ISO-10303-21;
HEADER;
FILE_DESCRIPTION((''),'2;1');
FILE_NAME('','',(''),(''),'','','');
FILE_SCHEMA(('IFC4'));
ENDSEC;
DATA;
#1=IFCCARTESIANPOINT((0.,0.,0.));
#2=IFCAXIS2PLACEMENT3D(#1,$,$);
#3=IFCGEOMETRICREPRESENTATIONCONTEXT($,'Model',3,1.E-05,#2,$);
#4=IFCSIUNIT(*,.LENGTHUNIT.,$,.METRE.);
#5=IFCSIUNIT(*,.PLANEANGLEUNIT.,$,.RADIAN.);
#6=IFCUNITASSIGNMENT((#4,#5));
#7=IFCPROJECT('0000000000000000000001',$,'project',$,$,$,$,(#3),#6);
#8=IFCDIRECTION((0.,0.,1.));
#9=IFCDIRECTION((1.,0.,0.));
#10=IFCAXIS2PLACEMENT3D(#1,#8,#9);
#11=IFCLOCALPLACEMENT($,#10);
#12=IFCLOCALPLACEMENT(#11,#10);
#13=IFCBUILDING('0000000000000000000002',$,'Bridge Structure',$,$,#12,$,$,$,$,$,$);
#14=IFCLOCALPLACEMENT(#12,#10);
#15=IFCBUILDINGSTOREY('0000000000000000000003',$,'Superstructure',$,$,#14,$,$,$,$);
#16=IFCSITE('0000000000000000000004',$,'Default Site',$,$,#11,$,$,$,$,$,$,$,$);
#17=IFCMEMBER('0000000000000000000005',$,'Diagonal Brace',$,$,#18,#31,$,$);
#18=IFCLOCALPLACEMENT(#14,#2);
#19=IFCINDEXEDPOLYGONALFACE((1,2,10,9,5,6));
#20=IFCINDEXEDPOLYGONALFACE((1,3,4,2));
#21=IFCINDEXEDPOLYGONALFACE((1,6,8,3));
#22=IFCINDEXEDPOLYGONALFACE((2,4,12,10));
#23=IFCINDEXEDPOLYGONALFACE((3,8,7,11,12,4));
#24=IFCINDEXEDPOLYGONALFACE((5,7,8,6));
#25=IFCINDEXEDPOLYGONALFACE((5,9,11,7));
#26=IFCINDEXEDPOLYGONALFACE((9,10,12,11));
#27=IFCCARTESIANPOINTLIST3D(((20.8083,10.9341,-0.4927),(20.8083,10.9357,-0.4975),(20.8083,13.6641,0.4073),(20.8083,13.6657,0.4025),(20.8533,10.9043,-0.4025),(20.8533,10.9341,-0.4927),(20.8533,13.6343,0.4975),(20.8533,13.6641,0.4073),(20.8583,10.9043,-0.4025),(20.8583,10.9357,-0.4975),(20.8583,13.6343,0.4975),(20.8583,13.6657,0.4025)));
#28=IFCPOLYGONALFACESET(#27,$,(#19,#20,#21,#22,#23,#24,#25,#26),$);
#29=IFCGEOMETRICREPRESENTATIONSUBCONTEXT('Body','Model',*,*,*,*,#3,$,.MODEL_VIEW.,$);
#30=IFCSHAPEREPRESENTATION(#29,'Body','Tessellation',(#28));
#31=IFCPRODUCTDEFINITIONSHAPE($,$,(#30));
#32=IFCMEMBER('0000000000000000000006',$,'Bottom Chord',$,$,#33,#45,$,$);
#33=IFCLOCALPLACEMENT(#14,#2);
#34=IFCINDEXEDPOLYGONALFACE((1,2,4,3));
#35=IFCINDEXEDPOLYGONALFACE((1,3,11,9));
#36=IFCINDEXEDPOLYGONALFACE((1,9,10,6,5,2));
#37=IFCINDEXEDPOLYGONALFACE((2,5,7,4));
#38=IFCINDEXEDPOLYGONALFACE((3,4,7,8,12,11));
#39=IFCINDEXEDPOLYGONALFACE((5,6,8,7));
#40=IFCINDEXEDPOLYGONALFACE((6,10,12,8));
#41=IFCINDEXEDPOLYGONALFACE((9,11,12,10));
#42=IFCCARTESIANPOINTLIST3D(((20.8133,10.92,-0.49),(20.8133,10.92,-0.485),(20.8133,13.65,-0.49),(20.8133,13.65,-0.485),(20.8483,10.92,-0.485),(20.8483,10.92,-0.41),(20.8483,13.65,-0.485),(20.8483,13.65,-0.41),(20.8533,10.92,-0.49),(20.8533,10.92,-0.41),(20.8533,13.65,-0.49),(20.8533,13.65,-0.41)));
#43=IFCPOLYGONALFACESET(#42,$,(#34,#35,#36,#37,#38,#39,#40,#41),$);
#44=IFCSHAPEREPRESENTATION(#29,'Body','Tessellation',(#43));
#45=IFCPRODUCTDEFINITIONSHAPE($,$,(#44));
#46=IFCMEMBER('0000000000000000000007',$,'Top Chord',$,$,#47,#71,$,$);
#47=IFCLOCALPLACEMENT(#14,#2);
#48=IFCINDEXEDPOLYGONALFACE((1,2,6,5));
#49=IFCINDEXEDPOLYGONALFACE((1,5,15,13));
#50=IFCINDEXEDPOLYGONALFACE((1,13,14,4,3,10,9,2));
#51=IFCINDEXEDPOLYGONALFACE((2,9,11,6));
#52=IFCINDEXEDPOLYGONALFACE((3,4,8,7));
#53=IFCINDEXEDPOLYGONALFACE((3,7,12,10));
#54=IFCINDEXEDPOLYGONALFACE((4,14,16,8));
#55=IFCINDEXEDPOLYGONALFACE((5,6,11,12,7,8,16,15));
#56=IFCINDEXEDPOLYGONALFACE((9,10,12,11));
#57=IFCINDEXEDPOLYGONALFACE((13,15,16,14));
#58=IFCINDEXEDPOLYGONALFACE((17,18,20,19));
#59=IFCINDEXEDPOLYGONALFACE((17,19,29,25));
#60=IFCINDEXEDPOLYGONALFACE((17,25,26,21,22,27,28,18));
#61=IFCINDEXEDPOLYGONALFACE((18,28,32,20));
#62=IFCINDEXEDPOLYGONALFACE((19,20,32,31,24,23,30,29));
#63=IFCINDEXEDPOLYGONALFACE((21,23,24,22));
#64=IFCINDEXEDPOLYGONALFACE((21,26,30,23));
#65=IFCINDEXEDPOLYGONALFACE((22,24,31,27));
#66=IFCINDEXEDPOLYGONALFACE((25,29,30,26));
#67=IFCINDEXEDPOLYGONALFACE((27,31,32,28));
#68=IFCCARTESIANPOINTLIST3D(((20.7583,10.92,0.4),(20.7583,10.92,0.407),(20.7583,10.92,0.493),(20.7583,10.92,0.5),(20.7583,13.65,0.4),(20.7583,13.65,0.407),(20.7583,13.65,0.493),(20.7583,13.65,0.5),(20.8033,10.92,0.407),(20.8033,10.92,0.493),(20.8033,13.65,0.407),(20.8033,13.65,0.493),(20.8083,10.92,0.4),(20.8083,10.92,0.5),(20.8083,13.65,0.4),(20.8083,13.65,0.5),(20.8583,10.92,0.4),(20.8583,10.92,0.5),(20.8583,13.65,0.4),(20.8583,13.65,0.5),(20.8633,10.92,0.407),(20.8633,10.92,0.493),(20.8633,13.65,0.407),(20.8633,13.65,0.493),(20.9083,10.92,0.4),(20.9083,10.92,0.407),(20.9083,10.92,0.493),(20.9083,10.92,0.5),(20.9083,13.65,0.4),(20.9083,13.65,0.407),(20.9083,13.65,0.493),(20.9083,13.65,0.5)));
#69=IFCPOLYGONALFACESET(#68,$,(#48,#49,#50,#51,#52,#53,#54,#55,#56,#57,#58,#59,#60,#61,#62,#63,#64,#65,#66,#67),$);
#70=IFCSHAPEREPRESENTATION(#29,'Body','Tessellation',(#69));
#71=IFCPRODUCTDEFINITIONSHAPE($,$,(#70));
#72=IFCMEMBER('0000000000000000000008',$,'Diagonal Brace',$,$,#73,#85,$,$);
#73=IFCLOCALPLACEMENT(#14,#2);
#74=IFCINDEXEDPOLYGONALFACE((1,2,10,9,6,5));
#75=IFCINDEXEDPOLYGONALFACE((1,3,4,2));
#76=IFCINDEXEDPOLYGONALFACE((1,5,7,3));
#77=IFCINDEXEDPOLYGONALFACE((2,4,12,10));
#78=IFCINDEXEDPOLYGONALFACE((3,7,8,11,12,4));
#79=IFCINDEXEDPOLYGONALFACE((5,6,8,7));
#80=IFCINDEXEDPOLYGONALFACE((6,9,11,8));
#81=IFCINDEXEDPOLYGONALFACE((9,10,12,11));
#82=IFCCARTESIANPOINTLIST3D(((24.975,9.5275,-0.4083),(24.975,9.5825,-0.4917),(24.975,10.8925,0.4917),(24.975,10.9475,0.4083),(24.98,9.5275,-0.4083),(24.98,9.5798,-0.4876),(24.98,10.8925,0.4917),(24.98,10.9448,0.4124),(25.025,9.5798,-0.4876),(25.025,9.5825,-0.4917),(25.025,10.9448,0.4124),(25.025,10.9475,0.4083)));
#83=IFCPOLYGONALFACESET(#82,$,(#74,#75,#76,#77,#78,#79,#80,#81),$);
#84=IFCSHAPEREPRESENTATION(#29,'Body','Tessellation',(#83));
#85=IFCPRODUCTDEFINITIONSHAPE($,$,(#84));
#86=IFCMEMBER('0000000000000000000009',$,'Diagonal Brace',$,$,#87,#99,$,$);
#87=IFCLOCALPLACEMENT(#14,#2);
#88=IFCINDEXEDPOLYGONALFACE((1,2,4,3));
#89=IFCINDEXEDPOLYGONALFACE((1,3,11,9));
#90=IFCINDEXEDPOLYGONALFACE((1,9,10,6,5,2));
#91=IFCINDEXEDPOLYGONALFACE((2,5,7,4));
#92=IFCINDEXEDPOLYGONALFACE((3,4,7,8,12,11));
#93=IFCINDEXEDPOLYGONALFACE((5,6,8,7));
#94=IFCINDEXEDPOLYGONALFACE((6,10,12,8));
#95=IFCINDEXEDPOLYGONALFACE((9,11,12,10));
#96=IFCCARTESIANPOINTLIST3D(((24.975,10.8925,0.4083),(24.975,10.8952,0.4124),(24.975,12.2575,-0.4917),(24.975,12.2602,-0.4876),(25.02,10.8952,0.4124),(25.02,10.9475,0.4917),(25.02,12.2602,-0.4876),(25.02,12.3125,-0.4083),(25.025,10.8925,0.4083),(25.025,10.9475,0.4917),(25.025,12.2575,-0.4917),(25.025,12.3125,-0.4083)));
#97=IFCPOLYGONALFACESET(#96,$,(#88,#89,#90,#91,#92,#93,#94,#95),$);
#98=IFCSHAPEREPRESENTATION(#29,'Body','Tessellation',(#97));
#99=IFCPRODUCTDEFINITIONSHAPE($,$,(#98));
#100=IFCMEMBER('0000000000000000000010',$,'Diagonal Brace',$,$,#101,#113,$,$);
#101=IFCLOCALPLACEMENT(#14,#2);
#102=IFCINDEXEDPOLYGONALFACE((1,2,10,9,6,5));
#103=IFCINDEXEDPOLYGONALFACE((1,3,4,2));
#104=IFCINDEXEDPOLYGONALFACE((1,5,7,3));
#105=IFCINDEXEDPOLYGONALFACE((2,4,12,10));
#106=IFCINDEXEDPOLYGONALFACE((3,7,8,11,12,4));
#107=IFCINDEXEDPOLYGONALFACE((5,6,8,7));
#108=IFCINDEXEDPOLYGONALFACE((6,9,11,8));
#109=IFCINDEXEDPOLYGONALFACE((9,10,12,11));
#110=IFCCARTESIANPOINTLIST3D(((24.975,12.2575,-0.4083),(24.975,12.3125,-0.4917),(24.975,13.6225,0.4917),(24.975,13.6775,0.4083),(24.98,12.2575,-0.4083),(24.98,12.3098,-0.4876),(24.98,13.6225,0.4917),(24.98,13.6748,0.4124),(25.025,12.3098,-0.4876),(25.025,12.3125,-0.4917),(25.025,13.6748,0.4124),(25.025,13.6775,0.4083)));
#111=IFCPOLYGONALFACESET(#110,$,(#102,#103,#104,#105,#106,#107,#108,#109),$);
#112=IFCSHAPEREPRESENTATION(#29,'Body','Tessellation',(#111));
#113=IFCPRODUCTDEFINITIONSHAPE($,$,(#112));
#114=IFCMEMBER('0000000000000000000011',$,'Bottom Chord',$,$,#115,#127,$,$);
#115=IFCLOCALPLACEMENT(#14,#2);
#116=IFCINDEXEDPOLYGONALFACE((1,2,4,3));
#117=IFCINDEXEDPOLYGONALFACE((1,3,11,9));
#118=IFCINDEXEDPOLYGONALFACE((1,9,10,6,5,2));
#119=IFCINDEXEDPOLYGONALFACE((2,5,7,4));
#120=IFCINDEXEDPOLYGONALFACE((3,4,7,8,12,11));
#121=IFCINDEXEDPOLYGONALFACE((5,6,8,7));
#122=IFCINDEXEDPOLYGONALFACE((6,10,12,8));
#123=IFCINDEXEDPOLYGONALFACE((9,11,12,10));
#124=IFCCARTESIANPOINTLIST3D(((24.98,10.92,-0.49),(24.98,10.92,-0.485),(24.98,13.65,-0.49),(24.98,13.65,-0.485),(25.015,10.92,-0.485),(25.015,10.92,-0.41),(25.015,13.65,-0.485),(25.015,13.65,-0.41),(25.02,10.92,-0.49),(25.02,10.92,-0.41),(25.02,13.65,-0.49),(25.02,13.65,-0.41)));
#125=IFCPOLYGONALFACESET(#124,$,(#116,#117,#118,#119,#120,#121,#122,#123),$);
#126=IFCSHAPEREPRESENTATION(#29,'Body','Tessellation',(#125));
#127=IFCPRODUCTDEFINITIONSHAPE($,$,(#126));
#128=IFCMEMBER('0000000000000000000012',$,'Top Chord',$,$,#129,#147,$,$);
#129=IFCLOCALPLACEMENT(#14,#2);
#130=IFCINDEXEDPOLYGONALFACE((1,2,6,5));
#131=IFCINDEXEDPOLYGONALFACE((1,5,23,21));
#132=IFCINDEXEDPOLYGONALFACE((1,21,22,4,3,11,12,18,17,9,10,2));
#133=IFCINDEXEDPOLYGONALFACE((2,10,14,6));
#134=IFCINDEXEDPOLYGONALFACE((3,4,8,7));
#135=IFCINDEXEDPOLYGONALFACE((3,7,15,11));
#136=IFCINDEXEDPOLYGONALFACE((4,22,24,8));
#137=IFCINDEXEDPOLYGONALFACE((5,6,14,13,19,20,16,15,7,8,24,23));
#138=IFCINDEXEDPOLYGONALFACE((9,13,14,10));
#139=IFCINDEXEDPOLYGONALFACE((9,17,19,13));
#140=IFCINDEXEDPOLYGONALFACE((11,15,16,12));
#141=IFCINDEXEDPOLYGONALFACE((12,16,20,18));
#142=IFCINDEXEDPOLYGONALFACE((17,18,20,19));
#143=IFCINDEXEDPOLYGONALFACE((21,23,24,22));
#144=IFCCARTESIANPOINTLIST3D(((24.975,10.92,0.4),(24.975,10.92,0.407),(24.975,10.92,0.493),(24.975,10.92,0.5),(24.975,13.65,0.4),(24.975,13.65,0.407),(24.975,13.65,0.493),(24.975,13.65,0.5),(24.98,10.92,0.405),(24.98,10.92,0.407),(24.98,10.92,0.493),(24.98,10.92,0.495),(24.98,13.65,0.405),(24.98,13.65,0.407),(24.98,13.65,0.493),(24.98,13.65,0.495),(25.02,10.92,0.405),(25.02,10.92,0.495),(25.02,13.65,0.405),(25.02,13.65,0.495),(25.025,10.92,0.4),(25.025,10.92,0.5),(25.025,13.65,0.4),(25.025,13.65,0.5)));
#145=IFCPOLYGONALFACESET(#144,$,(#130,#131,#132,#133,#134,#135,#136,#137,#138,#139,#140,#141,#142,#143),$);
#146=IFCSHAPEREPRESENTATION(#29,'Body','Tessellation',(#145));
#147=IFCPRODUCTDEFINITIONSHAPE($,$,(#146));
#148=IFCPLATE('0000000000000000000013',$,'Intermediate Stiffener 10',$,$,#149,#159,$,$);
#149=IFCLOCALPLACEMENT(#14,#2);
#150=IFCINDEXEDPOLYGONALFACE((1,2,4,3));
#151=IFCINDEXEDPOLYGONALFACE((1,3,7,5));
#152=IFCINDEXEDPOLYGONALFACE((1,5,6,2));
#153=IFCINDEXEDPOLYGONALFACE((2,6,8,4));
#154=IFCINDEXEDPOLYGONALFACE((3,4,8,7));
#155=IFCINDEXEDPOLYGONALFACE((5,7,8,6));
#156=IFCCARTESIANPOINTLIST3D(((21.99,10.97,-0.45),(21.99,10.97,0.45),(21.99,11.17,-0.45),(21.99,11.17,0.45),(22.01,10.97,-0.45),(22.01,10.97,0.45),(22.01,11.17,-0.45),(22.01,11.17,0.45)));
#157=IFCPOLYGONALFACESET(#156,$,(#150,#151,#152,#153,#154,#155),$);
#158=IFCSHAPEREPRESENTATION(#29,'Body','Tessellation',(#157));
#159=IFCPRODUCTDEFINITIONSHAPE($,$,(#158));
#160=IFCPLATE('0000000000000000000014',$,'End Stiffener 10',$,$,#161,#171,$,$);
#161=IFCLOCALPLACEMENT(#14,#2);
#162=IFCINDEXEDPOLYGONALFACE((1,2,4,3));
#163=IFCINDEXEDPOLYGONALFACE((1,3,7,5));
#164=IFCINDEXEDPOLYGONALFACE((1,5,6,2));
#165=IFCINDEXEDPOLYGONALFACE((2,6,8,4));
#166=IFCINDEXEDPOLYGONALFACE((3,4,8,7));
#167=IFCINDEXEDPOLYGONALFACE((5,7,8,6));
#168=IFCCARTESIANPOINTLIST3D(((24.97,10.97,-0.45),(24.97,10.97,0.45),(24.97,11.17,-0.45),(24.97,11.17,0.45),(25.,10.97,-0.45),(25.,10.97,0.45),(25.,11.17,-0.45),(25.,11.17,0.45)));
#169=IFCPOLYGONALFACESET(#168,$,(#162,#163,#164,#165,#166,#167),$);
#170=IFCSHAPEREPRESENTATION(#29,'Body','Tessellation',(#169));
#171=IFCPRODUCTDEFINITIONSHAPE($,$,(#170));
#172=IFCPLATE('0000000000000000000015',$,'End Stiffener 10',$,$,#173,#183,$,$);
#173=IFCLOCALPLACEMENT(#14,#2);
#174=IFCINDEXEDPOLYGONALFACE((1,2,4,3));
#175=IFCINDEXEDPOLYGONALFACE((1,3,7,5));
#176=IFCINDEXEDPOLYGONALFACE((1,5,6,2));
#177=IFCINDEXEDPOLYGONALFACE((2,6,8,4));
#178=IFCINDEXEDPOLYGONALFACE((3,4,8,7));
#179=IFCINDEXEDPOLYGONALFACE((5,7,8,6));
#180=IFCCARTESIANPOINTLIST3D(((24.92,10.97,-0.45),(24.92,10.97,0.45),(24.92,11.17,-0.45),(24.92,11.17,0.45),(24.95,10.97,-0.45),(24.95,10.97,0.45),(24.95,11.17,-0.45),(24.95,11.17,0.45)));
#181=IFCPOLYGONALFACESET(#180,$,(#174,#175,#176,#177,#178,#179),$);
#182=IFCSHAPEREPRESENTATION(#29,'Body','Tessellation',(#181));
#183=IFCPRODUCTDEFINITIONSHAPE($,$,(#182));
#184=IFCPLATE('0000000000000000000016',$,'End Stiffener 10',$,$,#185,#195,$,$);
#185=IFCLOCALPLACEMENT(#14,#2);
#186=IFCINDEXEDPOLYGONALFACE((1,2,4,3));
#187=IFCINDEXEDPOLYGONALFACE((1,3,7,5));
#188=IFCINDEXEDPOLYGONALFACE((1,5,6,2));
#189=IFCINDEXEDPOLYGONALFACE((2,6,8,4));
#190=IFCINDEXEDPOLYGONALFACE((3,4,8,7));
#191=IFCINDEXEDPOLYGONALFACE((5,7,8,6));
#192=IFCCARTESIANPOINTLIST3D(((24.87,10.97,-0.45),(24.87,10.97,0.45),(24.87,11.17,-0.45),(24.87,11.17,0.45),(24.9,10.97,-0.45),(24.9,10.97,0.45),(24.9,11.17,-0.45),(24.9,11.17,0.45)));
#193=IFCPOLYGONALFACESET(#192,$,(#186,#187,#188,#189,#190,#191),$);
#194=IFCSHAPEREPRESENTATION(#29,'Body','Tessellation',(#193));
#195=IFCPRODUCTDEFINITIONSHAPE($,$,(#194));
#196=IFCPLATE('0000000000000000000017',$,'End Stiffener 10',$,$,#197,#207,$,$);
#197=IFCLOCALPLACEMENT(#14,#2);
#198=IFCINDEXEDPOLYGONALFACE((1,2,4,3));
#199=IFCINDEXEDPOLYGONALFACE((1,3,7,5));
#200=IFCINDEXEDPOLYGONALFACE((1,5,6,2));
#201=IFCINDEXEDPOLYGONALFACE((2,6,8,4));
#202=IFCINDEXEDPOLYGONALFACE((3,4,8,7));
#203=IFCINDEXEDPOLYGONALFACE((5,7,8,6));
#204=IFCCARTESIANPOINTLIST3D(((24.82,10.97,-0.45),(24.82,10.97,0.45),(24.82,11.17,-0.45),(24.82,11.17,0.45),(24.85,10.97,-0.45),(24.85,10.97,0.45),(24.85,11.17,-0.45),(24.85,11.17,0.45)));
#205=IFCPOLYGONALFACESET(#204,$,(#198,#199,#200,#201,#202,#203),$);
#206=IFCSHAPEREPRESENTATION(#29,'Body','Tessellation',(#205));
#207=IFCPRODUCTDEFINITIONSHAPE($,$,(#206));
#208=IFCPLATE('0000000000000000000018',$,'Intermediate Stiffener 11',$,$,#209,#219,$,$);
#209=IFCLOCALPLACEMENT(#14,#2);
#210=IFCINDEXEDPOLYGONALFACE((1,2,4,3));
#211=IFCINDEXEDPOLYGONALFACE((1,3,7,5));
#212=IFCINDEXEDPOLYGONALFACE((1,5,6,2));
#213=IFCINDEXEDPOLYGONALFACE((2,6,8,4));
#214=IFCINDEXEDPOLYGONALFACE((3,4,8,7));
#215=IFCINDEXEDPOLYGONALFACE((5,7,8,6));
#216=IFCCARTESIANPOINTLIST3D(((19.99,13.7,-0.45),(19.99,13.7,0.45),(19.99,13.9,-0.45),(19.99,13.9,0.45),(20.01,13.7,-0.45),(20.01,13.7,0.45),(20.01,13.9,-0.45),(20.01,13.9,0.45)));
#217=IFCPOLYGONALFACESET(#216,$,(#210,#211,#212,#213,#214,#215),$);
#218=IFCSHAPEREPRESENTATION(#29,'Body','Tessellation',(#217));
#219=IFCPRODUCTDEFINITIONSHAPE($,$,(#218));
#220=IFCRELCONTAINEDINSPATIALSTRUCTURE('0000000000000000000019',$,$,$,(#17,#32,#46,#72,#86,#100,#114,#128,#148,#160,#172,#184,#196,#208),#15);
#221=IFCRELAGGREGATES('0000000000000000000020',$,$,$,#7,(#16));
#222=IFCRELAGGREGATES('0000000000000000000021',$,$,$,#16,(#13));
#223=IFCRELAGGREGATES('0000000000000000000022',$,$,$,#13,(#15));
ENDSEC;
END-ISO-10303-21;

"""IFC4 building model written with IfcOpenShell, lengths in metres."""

from ifc_helpers import new_model, si_unit, frame, origin, origin_with_axes, origin_2d_with_axis, place, context, subcontext, project, spatial, polyline, rectangle, l_section, c_section, outline, composite_profile, extrude, element, save


model = new_model("IFC4")

# Units and contexts
model_context = context("Model", 3, precision=1e-05, world=origin())
body_context = subcontext(model_context, "Body", "Model", "MODEL_VIEW")
ifc_project = project(units=[si_unit("LENGTHUNIT", "METRE"), si_unit("PLANEANGLEUNIT", "RADIAN")], contexts=[model_context])

# Site, building, storey
site_placement = place(None, origin_with_axes())
site = spatial("IfcSite", under=ifc_project, at=site_placement, Name="Default Site")
building_placement = place(site_placement, origin_with_axes())
building = spatial("IfcBuilding", under=site, at=building_placement, Name="Bridge Structure")
storey_placement = place(building_placement, origin_with_axes())
storey = spatial("IfcBuildingStorey", under=building, at=storey_placement, Name="Superstructure")

# Members
member_1_placement = place(storey_placement, frame((20.8333, 10.92, -0.45), z_axis=(0.0, 0.949722, 0.313095), x_axis=(-1.0, 0.0, 0.0)))
element("IfcMember", 1, at=member_1_placement, inside=storey, Name="Diagonal Brace", context=body_context, shape_type="SweptSolid", body=[
    extrude(l_section(Depth=0.1, Width=0.05, Thickness=0.005, at=origin_2d_with_axis()), origin_with_axes(), (0.0, 0.0, 1.0), 2.8745),
])
member_2_placement = place(storey_placement, frame((20.8333, 10.92, -0.45), z_axis=(0.0, 1.0, 0.0), x_axis=(-1.0, 0.0, 0.0)))
element("IfcMember", 2, at=member_2_placement, inside=storey, Name="Bottom Chord", context=body_context, shape_type="SweptSolid", body=[
    extrude(l_section(Depth=0.08, Width=0.04, Thickness=0.005, at=origin_2d_with_axis()), origin_with_axes(), (0.0, 0.0, 1.0), 2.73),
])
member_3_placement = place(storey_placement, frame((20.8333, 10.92, 0.45), z_axis=(0.0, 1.0, 0.0), x_axis=(-1.0, 0.0, 0.0)))
element("IfcMember", 3, at=member_3_placement, inside=storey, Name="Top Chord", context=body_context, shape_type="SweptSolid", body=[
    extrude(composite_profile([outline(polyline([(-0.025, -0.05), (-0.025, 0.05), (-0.075, 0.05), (-0.075, 0.043), (-0.03, 0.043), (-0.03, -0.043), (-0.075, -0.043), (-0.075, -0.05), (-0.025, -0.05)])), outline(polyline([(0.025, -0.05), (0.075, -0.05), (0.075, -0.043), (0.03, -0.043), (0.03, 0.043), (0.075, 0.043), (0.075, 0.05), (0.025, 0.05), (0.025, -0.05)]))]), origin_with_axes(), (0.0, 0.0, 1.0), 2.73),
])
for number, where, z_axis, x_axis, name in (
    (4, (25.0, 10.92, 0.45), (0.0, -0.834862, -0.550459), (1.0, 0.0, 0.0), "Diagonal Brace"),
    (5, (25.0, 10.92, 0.45), (0.0, 0.834862, -0.550459), (-1.0, 0.0, 0.0), "Diagonal Brace"),
    (6, (25.0, 13.65, 0.45), (0.0, -0.834862, -0.550459), (1.0, 0.0, 0.0), "Diagonal Brace"),
):
    element("IfcMember", number, at=place(storey_placement, frame(where, z_axis=z_axis, x_axis=x_axis)), inside=storey, Name=name, context=body_context, shape_type="SweptSolid", body=[
        extrude(l_section(Depth=0.1, Width=0.05, Thickness=0.005, at=origin_2d_with_axis()), origin_with_axes(), (0.0, 0.0, 1.0), 1.635),
    ])
member_4_placement = place(storey_placement, frame((25.0, 10.92, -0.45), z_axis=(0.0, 1.0, 0.0), x_axis=(-1.0, 0.0, 0.0)))
element("IfcMember", 7, at=member_4_placement, inside=storey, Name="Bottom Chord", context=body_context, shape_type="SweptSolid", body=[
    extrude(l_section(Depth=0.08, Width=0.04, Thickness=0.005, at=origin_2d_with_axis()), origin_with_axes(), (0.0, 0.0, 1.0), 2.73),
])
member_5_placement = place(storey_placement, frame((25.0, 10.92, 0.45), z_axis=(0.0, 1.0, 0.0), x_axis=(-1.0, 0.0, 0.0)))
element("IfcMember", 8, at=member_5_placement, inside=storey, Name="Top Chord", context=body_context, shape_type="SweptSolid", body=[
    extrude(c_section(Depth=0.1, Width=0.05, WallThickness=0.005, Girth=0.007, at=origin_2d_with_axis()), origin_with_axes(), (0.0, 0.0, 1.0), 2.73),
])

# Plates
plate_placement = place(storey_placement, frame((22.0, 11.07, -0.45), z_axis=(0.0, 0.0, 1.0), x_axis=(1.0, 0.0, 0.0)))
element("IfcPlate", 9, at=plate_placement, inside=storey, Name="Intermediate Stiffener 10", context=body_context, shape_type="SweptSolid", body=[
    extrude(rectangle(XDim=0.02, YDim=0.2, at=origin_2d_with_axis()), origin_with_axes(), (0.0, 0.0, 1.0), 0.9),
])
for number, where, z_axis, x_axis, name in (
    (10, (24.985, 11.07, -0.45), (0.0, 0.0, 1.0), (1.0, 0.0, 0.0), "End Stiffener 10"),
    (11, (24.935, 11.07, -0.45), (0.0, 0.0, 1.0), (1.0, 0.0, 0.0), "End Stiffener 10"),
    (12, (24.885, 11.07, -0.45), (0.0, 0.0, 1.0), (1.0, 0.0, 0.0), "End Stiffener 10"),
    (13, (24.835, 11.07, -0.45), (0.0, 0.0, 1.0), (1.0, 0.0, 0.0), "End Stiffener 10"),
):
    element("IfcPlate", number, at=place(storey_placement, frame(where, z_axis=z_axis, x_axis=x_axis)), inside=storey, Name=name, context=body_context, shape_type="SweptSolid", body=[
        extrude(rectangle(XDim=0.03, YDim=0.2, at=origin_2d_with_axis()), origin_with_axes(), (0.0, 0.0, 1.0), 0.9),
    ])
for number, where, z_axis, x_axis, name in (
    (14, (20.0, 13.8, -0.45), (0.0, 0.0, 1.0), (1.0, 0.0, 0.0), "Intermediate Stiffener 11"),
):
    element("IfcPlate", number, at=place(storey_placement, frame(where, z_axis=z_axis, x_axis=x_axis)), inside=storey, Name=name, context=body_context, shape_type="SweptSolid", body=[
        extrude(rectangle(XDim=0.02, YDim=0.2, at=origin_2d_with_axis()), origin_with_axes(), (0.0, 0.0, 1.0), 0.9),
    ])

save(model, "model.ifc")
